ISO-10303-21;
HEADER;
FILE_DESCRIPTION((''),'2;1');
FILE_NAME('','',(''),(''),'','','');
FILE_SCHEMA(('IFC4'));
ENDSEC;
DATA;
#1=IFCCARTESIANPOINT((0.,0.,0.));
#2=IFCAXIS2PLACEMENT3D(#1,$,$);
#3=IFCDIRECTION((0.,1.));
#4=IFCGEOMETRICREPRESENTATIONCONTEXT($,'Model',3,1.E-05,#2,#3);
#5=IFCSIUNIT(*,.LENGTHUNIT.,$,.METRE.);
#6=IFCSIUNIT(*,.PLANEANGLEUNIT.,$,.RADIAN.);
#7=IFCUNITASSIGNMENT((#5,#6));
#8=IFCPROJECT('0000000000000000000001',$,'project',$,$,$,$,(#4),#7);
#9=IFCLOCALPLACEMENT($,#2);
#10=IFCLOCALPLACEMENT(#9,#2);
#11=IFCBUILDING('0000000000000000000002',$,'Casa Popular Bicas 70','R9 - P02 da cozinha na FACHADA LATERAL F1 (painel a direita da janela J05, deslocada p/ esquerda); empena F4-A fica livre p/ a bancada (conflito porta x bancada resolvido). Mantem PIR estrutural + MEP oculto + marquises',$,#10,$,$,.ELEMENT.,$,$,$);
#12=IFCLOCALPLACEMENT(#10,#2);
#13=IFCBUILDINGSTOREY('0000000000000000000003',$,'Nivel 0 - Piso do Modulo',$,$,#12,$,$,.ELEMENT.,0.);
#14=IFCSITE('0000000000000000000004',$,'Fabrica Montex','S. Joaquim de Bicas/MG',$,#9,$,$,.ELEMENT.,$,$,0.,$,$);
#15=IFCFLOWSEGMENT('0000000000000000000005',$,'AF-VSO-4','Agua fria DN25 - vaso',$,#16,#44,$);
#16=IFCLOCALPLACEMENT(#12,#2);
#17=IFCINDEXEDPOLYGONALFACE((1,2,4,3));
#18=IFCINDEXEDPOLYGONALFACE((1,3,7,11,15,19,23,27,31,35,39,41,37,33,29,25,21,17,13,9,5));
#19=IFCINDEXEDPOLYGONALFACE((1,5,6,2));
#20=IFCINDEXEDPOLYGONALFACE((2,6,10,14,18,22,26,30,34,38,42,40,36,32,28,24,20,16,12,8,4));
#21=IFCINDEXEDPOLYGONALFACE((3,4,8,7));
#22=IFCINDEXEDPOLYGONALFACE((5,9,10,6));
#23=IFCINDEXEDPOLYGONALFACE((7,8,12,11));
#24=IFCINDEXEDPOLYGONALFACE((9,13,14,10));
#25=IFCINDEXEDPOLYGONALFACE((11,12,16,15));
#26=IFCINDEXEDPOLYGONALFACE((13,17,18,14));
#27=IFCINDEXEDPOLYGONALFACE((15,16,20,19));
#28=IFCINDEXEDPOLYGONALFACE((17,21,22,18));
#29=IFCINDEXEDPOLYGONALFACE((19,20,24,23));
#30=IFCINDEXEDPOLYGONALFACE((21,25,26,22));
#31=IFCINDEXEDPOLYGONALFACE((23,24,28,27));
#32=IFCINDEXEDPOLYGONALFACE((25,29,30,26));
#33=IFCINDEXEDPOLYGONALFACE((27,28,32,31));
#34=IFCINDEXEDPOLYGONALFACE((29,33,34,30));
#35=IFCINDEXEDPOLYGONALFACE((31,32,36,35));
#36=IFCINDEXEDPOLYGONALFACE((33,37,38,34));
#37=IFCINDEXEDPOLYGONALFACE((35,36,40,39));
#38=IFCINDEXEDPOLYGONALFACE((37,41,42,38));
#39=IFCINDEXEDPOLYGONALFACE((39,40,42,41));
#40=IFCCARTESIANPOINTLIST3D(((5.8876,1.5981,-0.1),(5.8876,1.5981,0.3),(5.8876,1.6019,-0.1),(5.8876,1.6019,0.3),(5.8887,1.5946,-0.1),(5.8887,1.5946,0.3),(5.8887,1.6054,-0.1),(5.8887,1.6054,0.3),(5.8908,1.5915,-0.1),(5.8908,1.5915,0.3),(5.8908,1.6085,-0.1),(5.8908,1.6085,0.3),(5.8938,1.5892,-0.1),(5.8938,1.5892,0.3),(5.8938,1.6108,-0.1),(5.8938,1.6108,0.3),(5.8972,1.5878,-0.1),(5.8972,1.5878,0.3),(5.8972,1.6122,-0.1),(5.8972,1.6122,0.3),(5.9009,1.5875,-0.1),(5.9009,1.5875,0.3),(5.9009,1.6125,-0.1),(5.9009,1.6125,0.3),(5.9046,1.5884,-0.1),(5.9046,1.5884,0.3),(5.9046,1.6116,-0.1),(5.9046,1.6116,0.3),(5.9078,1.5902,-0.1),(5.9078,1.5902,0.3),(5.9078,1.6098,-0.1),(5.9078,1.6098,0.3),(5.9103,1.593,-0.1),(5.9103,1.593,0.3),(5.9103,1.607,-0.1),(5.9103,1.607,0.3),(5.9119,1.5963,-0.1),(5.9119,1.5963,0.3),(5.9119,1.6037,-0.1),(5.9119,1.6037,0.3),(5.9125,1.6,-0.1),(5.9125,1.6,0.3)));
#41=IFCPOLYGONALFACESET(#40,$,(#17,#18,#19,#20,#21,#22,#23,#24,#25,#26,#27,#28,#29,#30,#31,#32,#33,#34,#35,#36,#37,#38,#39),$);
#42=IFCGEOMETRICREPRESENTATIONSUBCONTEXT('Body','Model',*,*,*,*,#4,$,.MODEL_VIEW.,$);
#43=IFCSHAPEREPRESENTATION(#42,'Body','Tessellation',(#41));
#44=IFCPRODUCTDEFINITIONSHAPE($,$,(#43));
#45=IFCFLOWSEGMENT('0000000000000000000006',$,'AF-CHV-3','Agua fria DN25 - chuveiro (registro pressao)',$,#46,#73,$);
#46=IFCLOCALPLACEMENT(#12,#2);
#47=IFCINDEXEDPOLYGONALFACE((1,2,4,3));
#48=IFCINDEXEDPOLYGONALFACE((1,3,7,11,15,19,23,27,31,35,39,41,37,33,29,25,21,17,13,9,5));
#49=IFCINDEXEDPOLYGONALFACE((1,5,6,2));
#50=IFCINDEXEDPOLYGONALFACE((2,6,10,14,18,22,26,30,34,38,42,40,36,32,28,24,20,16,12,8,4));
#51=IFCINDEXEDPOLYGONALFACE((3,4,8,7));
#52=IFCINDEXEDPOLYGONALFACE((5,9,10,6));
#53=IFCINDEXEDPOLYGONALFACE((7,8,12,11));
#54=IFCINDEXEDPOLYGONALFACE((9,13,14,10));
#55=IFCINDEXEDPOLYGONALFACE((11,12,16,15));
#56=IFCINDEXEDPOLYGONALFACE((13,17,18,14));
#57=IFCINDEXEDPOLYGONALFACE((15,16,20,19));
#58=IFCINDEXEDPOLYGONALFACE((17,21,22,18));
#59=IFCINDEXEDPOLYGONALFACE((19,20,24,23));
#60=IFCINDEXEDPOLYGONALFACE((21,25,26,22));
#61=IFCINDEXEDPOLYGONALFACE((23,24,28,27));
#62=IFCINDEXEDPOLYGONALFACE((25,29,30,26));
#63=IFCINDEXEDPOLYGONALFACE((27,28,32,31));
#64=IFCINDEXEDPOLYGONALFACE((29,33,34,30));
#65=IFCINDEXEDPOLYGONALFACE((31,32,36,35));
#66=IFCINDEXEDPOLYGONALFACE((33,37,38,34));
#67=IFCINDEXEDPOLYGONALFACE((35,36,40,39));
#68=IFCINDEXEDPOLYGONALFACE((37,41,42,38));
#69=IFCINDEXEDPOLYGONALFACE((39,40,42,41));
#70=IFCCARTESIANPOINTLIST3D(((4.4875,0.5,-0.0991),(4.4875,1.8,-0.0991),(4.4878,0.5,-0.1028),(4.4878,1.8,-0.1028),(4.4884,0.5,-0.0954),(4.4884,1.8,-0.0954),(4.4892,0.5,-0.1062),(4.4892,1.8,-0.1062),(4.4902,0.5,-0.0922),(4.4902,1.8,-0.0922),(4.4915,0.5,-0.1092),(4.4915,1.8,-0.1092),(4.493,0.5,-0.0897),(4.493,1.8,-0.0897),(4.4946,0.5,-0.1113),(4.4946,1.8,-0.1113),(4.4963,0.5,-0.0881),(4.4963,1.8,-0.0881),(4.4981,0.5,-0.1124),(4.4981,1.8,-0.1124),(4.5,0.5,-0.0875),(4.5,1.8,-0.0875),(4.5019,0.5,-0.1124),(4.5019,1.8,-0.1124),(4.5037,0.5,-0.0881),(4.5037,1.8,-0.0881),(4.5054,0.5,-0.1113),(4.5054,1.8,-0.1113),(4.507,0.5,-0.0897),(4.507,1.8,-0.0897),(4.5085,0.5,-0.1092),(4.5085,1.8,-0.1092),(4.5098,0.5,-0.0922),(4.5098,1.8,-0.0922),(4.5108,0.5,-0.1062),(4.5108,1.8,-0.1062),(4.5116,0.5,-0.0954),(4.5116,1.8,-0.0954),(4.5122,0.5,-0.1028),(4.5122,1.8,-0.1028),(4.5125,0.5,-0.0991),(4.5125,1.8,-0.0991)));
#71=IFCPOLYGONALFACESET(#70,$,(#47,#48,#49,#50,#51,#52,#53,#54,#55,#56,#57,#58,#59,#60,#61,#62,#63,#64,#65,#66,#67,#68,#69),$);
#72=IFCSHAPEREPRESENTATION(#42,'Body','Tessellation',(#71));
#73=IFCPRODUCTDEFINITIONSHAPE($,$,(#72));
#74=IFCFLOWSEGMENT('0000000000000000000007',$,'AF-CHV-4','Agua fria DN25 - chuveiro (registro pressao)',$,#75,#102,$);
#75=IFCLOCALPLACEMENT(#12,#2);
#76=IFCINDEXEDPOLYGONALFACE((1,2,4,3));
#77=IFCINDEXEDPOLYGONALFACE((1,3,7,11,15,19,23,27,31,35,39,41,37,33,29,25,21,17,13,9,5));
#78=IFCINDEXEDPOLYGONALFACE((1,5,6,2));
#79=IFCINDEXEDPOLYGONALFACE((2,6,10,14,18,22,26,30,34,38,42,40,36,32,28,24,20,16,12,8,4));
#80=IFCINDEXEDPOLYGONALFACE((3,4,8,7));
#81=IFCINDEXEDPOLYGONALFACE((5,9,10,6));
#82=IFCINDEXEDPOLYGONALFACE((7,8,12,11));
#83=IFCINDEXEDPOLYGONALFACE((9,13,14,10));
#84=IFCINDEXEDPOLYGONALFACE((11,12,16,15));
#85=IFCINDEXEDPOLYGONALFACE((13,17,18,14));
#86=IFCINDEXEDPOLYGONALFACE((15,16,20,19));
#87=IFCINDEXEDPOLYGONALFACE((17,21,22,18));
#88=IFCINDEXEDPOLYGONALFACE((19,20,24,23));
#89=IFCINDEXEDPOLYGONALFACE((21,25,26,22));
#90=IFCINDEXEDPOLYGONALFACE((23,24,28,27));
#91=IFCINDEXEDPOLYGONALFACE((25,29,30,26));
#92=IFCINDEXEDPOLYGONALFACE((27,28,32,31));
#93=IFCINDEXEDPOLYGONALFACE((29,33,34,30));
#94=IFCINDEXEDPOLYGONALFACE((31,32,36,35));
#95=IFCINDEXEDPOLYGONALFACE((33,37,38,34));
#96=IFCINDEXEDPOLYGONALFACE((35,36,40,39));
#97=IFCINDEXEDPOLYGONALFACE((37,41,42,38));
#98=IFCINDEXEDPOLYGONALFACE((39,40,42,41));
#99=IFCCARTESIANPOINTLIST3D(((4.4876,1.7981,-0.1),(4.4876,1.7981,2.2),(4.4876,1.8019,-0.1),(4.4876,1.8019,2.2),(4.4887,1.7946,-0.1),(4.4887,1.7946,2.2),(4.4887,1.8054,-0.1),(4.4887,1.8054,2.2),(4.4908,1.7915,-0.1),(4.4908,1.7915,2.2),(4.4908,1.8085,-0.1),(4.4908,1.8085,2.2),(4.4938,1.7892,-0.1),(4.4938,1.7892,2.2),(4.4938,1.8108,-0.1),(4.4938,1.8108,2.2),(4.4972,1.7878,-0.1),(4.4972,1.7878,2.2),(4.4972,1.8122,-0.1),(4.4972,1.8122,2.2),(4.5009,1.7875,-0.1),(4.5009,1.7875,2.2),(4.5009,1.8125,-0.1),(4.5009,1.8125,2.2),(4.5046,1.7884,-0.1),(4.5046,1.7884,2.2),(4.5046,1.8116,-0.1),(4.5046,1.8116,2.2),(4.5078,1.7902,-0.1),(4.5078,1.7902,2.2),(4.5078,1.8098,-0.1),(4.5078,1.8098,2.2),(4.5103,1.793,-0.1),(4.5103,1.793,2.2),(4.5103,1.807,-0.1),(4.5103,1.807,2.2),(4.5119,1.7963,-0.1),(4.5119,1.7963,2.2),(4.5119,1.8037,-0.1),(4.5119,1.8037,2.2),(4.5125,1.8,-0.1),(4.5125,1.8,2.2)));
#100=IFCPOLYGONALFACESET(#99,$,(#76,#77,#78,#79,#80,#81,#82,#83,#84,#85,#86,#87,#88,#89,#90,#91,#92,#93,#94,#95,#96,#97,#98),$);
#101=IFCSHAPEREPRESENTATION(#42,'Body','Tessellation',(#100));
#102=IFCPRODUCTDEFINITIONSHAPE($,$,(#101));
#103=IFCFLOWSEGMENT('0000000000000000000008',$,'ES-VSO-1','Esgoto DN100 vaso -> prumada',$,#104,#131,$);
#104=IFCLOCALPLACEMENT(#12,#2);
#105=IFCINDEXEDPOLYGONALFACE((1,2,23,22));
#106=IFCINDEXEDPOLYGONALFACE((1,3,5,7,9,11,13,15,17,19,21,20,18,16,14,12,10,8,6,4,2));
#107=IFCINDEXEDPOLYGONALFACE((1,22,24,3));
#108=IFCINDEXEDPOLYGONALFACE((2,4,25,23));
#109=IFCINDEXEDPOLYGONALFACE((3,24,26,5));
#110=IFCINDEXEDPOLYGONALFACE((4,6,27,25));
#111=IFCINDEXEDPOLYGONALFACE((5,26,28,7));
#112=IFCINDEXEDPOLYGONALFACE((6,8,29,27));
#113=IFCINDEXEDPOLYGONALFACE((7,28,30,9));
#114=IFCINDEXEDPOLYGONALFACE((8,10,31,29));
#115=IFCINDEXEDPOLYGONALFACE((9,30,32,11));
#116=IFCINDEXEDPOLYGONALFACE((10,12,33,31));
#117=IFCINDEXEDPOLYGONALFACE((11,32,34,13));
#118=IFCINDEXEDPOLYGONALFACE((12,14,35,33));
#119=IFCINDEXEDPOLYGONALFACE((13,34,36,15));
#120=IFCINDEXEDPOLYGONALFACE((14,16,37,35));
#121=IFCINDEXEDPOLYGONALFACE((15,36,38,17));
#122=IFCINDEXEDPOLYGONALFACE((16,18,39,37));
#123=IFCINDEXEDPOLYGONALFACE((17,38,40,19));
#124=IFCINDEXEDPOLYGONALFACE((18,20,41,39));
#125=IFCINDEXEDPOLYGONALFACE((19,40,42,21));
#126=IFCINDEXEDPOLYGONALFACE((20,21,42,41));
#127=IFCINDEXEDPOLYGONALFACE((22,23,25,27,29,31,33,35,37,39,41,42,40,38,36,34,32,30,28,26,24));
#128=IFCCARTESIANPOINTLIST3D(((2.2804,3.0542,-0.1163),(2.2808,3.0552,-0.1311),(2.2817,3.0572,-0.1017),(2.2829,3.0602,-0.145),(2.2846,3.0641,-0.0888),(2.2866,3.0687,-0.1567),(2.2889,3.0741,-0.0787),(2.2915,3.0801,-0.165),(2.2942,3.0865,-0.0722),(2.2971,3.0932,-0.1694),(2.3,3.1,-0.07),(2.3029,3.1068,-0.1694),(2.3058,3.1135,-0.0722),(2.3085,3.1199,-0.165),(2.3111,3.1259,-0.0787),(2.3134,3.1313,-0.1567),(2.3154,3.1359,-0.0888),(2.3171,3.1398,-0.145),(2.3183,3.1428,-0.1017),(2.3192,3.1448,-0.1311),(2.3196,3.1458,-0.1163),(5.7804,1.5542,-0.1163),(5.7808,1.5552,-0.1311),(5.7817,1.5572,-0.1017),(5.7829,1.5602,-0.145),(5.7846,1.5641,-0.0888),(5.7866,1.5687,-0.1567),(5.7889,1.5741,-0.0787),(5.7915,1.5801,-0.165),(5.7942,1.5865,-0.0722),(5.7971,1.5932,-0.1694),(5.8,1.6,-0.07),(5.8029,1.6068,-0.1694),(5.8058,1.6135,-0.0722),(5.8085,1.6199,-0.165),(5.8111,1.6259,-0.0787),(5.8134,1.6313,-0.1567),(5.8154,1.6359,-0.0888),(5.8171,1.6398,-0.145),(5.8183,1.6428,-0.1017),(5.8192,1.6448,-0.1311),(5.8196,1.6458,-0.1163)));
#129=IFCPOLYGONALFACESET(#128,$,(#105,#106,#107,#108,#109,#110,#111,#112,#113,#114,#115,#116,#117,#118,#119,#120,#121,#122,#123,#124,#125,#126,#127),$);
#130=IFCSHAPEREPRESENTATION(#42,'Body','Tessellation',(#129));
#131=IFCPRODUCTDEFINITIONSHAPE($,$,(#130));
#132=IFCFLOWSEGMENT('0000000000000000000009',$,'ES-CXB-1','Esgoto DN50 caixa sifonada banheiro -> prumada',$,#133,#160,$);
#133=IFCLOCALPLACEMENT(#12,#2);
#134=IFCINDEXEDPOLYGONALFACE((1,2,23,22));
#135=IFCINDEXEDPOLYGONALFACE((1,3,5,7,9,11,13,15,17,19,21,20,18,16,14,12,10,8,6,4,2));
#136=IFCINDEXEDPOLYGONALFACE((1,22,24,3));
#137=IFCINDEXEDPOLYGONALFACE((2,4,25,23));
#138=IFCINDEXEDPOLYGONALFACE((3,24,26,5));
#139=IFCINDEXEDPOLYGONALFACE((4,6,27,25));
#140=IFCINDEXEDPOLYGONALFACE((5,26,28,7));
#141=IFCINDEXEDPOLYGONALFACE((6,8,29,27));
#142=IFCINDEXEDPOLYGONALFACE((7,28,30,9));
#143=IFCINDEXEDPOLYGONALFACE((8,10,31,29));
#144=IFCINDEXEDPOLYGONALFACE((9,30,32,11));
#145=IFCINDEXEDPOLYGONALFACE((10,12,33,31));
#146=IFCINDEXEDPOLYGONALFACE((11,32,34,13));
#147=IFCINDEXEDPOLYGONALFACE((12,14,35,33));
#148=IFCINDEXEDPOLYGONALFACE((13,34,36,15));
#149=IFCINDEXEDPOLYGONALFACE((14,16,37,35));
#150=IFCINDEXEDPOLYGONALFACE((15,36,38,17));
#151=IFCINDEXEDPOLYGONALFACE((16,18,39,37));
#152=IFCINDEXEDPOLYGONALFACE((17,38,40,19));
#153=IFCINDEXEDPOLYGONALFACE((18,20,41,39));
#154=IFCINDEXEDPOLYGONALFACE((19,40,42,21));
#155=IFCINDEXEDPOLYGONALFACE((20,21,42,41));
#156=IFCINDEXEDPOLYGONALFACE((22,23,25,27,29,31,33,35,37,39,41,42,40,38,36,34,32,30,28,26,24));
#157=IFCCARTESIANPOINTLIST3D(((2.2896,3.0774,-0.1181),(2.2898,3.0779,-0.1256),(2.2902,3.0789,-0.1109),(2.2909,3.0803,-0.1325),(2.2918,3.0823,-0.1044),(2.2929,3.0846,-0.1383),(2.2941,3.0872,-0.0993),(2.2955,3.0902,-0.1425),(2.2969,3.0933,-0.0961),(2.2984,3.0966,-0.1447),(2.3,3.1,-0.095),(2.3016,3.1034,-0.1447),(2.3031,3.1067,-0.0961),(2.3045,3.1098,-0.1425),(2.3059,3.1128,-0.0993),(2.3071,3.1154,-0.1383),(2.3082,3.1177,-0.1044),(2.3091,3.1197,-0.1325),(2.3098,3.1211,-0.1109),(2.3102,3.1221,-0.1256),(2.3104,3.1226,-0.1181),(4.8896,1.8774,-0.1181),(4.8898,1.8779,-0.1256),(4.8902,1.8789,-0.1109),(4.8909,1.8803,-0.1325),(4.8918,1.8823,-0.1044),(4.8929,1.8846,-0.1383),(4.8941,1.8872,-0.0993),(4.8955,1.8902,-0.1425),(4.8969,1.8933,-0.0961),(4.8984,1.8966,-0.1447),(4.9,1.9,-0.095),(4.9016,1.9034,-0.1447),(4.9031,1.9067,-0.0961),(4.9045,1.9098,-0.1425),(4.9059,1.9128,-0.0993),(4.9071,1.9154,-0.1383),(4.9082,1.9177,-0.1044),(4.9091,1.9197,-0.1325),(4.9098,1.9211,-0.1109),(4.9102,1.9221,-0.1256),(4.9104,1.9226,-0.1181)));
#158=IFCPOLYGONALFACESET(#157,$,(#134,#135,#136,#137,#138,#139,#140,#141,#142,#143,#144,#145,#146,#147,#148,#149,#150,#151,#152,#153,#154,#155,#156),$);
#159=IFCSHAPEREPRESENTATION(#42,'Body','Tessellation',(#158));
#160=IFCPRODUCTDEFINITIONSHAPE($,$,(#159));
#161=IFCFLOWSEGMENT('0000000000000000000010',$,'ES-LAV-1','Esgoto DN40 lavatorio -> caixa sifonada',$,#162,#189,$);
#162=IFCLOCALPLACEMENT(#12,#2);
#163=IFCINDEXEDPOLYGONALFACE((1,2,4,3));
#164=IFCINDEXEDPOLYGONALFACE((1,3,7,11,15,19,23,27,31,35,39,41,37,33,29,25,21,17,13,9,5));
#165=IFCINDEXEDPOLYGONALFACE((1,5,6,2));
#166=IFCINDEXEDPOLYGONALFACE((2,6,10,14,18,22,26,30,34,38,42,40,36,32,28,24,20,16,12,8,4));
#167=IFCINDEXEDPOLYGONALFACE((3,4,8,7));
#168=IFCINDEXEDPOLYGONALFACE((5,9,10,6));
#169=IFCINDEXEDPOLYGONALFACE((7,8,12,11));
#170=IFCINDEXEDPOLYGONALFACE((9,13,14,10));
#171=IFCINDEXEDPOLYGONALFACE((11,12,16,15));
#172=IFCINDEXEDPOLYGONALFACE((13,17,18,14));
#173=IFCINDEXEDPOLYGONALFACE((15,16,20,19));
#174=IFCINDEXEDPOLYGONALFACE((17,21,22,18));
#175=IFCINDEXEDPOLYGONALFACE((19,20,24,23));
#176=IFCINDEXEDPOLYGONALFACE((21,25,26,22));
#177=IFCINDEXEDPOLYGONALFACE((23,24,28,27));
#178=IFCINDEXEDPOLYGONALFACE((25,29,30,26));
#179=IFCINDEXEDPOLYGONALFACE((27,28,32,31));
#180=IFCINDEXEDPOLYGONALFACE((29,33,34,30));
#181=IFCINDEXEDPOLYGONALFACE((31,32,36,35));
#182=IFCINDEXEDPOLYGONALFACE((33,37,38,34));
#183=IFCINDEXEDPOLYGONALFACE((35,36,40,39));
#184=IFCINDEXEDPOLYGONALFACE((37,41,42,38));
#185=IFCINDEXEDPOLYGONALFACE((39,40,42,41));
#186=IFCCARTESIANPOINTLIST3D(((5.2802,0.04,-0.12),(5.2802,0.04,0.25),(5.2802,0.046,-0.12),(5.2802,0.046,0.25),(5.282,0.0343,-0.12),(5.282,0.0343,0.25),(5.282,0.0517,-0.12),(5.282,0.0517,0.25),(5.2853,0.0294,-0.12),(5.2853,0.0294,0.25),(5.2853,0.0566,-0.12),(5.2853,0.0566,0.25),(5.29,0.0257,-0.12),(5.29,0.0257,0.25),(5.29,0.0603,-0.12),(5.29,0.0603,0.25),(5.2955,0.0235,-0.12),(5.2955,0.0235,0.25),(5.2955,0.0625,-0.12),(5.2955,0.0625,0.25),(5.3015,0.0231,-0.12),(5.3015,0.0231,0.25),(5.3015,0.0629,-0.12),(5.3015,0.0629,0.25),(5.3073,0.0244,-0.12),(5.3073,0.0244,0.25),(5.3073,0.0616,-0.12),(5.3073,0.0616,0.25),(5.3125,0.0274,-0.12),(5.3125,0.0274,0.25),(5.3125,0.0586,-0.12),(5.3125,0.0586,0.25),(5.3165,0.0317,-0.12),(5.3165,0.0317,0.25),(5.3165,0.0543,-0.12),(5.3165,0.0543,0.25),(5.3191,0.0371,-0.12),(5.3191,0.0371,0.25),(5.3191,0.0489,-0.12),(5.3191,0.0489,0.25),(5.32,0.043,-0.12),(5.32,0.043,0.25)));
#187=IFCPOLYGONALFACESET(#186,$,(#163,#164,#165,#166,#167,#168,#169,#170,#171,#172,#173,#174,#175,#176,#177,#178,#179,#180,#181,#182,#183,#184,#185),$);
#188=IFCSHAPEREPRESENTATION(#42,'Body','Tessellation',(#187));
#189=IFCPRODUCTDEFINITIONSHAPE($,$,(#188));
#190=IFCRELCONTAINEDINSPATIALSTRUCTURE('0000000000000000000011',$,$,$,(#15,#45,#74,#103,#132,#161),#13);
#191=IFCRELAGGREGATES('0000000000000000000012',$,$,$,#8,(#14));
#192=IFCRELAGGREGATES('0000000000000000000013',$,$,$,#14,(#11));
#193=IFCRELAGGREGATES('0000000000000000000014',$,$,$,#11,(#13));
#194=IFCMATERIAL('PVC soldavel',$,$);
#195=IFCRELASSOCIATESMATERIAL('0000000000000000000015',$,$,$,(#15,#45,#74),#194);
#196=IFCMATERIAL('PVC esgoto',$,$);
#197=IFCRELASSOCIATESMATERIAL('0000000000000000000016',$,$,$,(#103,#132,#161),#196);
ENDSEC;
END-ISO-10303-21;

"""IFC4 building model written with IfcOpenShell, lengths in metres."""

from ifc_helpers import new_model, si_unit, direction, frame, origin, origin_2d, place, context, subcontext, project, spatial, circle, extrude, material, element, save


model = new_model("IFC4")

# Units and contexts
model_context = context("Model", 3, precision=1e-05, world=origin(), true_north=direction((0.0, 1.0)))
body_context = subcontext(model_context, "Body", "Model", "MODEL_VIEW")
ifc_project = project(units=[si_unit("LENGTHUNIT", "METRE"), si_unit("PLANEANGLEUNIT", "RADIAN")], contexts=[model_context])

# Site, building, storey
site_placement = place(None, origin())
site = spatial("IfcSite", under=ifc_project, at=site_placement, Name="Fabrica Montex", Description="S. Joaquim de Bicas/MG", CompositionType="ELEMENT", RefElevation=0.0)
building_placement = place(site_placement, origin())
building = spatial("IfcBuilding", under=site, at=building_placement, Name="Casa Popular Bicas 70", Description="R9 - P02 da cozinha na FACHADA LATERAL F1 (painel a direita da janela J05, deslocada p/ esquerda); empena F4-A fica livre p/ a bancada (conflito porta x bancada resolvido). Mantem PIR estrutural + MEP oculto + marquises", CompositionType="ELEMENT")
storey_placement = place(building_placement, origin())
storey = spatial("IfcBuildingStorey", under=building, at=storey_placement, Name="Nivel 0 - Piso do Modulo", CompositionType="ELEMENT", Elevation=0.0)

# Flow segments
ifc_material_1 = material(Name="PVC soldavel")
flow_segment_1_placement = place(storey_placement, frame((5.9, 1.6, -0.1), z_axis=(0.0, 0.0, 1.0), x_axis=(1.0, 0.0, 0.0)))
element("IfcFlowSegment", 1, at=flow_segment_1_placement, inside=storey, material=ifc_material_1, Name="AF-VSO-4", Description="Agua fria DN25 - vaso", context=body_context, shape_type="SweptSolid", body=[
    extrude(circle(Radius=0.0125, at=origin_2d()), origin(), (0.0, 0.0, 1.0), 0.4),
])
flow_segment_2_placement = place(storey_placement, frame((4.5, 0.5, -0.1), z_axis=(0.0, 1.0, 0.0), x_axis=(0.0, 0.0, 1.0)))
element("IfcFlowSegment", 2, at=flow_segment_2_placement, inside=storey, material=ifc_material_1, Name="AF-CHV-3", Description="Agua fria DN25 - chuveiro (registro pressao)", context=body_context, shape_type="SweptSolid", body=[
    extrude(circle(Radius=0.0125, at=origin_2d()), origin(), (0.0, 0.0, 1.0), 1.3),
])
flow_segment_3_placement = place(storey_placement, frame((4.5, 1.8, -0.1), z_axis=(0.0, 0.0, 1.0), x_axis=(1.0, 0.0, 0.0)))
element("IfcFlowSegment", 3, at=flow_segment_3_placement, inside=storey, material=ifc_material_1, Name="AF-CHV-4", Description="Agua fria DN25 - chuveiro (registro pressao)", context=body_context, shape_type="SweptSolid", body=[
    extrude(circle(Radius=0.0125, at=origin_2d()), origin(), (0.0, 0.0, 1.0), 2.3),
])
ifc_material_2 = material(Name="PVC esgoto")
flow_segment_4_placement = place(storey_placement, frame((5.8, 1.6, -0.12), z_axis=(-0.919145, 0.393919, 0.0), x_axis=(0.0, 0.0, 1.0)))
element("IfcFlowSegment", 4, at=flow_segment_4_placement, inside=storey, material=ifc_material_2, Name="ES-VSO-1", Description="Esgoto DN100 vaso -> prumada", context=body_context, shape_type="SweptSolid", body=[
    extrude(circle(Radius=0.05, at=origin_2d()), origin(), (0.0, 0.0, 1.0), 3.8079),
])
flow_segment_5_placement = place(storey_placement, frame((4.9, 1.9, -0.12), z_axis=(-0.907959, 0.419058, 0.0), x_axis=(0.0, 0.0, 1.0)))
element("IfcFlowSegment", 5, at=flow_segment_5_placement, inside=storey, material=ifc_material_2, Name="ES-CXB-1", Description="Esgoto DN50 caixa sifonada banheiro -> prumada", context=body_context, shape_type="SweptSolid", body=[
    extrude(circle(Radius=0.025, at=origin_2d()), origin(), (0.0, 0.0, 1.0), 2.8636),
])
flow_segment_6_placement = place(storey_placement, frame((5.3, 0.043, 0.25), z_axis=(0.0, 0.0, -1.0), x_axis=(1.0, 0.0, 0.0)))
element("IfcFlowSegment", 6, at=flow_segment_6_placement, inside=storey, material=ifc_material_2, Name="ES-LAV-1", Description="Esgoto DN40 lavatorio -> caixa sifonada", context=body_context, shape_type="SweptSolid", body=[
    extrude(circle(Radius=0.02, at=origin_2d()), origin(), (0.0, 0.0, 1.0), 0.37),
])

save(model, "model.ifc")
